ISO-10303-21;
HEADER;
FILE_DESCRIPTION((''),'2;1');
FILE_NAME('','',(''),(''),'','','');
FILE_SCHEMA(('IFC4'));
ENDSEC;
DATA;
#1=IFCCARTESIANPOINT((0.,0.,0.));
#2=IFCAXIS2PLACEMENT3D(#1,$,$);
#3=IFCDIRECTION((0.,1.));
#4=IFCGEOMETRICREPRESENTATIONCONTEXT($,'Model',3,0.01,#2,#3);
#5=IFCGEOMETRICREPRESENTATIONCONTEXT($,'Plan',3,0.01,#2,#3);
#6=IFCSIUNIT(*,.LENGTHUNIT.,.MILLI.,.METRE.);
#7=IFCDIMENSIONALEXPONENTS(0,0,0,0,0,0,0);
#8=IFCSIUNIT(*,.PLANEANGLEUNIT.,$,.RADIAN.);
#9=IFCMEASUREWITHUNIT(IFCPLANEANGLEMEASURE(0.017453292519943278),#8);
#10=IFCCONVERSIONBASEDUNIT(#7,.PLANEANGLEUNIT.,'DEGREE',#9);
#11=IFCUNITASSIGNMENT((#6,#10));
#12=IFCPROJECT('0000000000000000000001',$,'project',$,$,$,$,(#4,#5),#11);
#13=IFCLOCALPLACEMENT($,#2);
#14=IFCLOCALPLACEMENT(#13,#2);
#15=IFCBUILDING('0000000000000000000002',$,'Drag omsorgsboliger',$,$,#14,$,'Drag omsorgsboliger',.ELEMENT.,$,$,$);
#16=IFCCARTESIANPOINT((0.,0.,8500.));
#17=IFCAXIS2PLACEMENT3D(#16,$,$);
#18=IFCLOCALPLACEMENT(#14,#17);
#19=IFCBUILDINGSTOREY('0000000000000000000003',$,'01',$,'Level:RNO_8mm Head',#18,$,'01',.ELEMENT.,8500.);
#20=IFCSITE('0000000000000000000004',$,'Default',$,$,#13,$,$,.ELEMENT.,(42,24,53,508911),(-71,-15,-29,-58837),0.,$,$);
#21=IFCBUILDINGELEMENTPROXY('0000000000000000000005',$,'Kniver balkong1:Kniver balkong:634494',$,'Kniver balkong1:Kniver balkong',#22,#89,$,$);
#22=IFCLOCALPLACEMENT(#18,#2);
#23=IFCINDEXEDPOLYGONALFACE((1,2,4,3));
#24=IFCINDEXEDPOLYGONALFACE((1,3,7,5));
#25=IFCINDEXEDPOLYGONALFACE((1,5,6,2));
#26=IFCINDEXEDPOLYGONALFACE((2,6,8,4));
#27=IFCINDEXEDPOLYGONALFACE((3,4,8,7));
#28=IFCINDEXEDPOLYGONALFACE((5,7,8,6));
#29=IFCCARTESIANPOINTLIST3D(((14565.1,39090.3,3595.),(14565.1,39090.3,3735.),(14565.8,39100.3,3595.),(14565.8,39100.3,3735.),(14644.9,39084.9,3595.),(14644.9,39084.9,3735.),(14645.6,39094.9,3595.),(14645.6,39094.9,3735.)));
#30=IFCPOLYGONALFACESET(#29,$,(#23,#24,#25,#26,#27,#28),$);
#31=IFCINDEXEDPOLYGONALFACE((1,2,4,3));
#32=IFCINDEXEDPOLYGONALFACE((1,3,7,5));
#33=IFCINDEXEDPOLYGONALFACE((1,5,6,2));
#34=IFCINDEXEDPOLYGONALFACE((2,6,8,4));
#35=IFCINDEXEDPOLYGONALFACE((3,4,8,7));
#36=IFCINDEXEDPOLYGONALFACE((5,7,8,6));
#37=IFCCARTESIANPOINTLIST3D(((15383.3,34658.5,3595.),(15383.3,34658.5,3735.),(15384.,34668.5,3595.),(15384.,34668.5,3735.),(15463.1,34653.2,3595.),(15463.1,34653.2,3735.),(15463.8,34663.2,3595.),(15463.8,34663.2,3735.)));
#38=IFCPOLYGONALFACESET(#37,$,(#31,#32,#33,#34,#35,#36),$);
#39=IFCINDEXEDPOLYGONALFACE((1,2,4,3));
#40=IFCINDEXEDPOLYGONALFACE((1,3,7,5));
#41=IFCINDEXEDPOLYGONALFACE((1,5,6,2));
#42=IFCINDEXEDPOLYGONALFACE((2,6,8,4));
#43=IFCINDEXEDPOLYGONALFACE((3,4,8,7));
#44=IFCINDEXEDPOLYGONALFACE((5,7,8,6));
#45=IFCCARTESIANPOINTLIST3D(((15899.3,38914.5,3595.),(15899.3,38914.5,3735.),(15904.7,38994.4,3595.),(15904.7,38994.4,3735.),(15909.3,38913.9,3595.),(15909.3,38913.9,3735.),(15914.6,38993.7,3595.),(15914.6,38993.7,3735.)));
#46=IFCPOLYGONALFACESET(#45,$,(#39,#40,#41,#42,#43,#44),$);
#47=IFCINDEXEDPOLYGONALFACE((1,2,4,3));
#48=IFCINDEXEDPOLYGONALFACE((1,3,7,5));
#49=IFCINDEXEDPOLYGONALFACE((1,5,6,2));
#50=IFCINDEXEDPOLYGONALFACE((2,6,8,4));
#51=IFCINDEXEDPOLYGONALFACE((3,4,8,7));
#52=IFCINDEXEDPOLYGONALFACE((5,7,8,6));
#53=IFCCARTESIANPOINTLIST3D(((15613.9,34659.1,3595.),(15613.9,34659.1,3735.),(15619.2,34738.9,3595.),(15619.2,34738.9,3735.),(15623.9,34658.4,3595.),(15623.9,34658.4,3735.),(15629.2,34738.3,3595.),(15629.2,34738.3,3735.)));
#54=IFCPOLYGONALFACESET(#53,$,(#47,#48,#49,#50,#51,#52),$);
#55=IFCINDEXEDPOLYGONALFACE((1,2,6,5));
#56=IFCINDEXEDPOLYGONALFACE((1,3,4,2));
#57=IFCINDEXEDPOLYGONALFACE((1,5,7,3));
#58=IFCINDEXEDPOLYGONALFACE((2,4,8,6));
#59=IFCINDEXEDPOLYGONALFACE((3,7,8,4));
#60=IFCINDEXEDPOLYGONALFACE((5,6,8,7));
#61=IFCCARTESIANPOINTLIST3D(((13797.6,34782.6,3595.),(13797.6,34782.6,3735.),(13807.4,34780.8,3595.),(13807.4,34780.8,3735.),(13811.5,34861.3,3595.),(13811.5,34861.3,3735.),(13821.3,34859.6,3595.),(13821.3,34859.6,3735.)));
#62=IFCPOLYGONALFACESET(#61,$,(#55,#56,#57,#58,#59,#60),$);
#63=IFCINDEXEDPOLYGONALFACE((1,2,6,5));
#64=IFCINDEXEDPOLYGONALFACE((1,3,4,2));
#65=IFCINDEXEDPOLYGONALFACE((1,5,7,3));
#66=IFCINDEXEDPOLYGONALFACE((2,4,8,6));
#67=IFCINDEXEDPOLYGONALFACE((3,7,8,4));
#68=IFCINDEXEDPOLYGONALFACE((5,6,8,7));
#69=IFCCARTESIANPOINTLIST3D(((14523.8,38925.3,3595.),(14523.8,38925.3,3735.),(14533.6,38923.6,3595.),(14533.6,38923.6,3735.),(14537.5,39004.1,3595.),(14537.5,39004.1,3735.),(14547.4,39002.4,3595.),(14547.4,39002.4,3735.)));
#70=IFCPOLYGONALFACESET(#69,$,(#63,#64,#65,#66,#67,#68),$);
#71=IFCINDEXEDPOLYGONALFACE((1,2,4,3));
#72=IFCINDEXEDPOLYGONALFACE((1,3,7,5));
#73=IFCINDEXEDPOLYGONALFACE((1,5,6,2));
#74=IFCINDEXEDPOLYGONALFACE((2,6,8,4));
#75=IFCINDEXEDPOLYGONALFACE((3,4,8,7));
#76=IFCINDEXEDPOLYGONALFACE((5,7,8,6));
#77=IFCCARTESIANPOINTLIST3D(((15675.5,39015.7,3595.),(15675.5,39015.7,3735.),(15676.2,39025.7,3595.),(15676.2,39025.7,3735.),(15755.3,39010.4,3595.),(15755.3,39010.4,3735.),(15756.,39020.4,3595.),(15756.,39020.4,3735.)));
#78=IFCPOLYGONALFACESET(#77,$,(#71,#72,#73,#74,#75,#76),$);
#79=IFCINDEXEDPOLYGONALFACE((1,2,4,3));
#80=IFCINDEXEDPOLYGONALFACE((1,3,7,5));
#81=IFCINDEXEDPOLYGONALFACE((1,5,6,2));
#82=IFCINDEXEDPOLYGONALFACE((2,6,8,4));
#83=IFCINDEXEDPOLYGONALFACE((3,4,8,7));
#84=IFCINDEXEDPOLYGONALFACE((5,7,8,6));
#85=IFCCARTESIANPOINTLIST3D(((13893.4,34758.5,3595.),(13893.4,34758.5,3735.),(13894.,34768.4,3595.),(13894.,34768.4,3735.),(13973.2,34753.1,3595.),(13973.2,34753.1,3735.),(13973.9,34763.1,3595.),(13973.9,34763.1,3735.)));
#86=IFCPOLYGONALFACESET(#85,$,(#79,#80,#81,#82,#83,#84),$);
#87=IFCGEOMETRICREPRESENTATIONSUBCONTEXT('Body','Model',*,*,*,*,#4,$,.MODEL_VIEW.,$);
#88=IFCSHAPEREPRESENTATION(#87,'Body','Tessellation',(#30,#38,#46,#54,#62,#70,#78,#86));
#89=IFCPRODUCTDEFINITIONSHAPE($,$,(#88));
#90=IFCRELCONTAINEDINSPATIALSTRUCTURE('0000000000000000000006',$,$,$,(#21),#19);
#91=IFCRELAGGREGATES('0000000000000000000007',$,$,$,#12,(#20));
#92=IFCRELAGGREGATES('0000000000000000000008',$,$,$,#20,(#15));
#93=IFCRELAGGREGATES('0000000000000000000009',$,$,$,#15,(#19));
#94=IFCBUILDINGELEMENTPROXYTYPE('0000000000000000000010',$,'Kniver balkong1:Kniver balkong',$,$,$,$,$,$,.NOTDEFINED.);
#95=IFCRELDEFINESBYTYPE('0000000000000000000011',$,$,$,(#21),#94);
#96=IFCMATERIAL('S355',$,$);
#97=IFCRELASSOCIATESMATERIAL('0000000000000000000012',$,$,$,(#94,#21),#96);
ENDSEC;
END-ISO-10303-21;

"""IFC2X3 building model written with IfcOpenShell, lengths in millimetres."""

from ifc_helpers import new_model, entity, si_unit, converted_unit, direction, frame, frame_2d, origin, place, context, subcontext, project, spatial, rectangle, extrude, source, transform, mapped, material, type_object, type_shapes, element, save


model = new_model("IFC2X3")

# Units and contexts
model_context = context("Model", 3, precision=0.01, world=origin(), true_north=direction((0.0, 1.0)))
plan_context = context("Plan", 3, precision=0.01, world=origin(), true_north=direction((0.0, 1.0)))
body_context = subcontext(model_context, "Body", "Model", "MODEL_VIEW")
ifc_project = project(units=[si_unit("LENGTHUNIT", "METRE", prefix="MILLI"), converted_unit("PLANEANGLEUNIT", "DEGREE", entity("IfcPlaneAngleMeasure", 0.017453292519943278), si_unit("PLANEANGLEUNIT", "RADIAN"), dimensions=[0, 0, 0, 0, 0, 0, 0])], contexts=[model_context, plan_context])

# Site, building, storey
site_placement = place(None, origin())
site = spatial("IfcSite", under=ifc_project, at=site_placement, Name="Default", CompositionType="ELEMENT", RefLatitude=(42, 24, 53, 508911), RefLongitude=(-71, -15, -29, -58837), RefElevation=0.0)
building_placement = place(site_placement, origin())
building = spatial("IfcBuilding", under=site, at=building_placement, Name="Drag omsorgsboliger", LongName="Drag omsorgsboliger", CompositionType="ELEMENT")
storey_placement = place(building_placement, frame((0.0, 0.0, 8500.0)))
storey = spatial("IfcBuildingStorey", under=building, at=storey_placement, Name="01", ObjectType="Level:RNO_8mm Head", LongName="01", CompositionType="ELEMENT", Elevation=8500.0)

# Shared definitions
ifc_material = material(Name="S355")

# Building element proxy
building_element_proxy_type_1 = type_object("IfcBuildingElementProxyType", Name="Kniver balkong1:Kniver balkong", PredefinedType="NOTDEFINED", material=ifc_material)
shared_shape_1 = source(origin(), body_context, "Body", "SweptSolid", [
    extrude(rectangle(XDim=10.0, YDim=80.0, at=frame_2d((0.0, 0.0), x_axis=(1.0, 0.0))), frame((14605.3, 39092.6, 12095.0), z_axis=(0.0, 0.0, 1.0), x_axis=(0.066923, 0.997758, 0.0)), (0.0, 0.0, 1.0), 140.0),
    extrude(rectangle(XDim=10.0, YDim=80.0, at=frame_2d((0.0, 0.0), x_axis=(1.0, 0.0))), frame((15423.6, 34660.8, 12095.0), z_axis=(0.0, 0.0, 1.0), x_axis=(0.066923, 0.997758, 0.0)), (0.0, 0.0, 1.0), 140.0),
    extrude(rectangle(XDim=80.0, YDim=10.0, at=frame_2d((0.0, 0.0), x_axis=(1.0, 0.0))), frame((15907.0, 38954.1, 12095.0), z_axis=(0.0, 0.0, 1.0), x_axis=(0.066923, 0.997758, 0.0)), (0.0, 0.0, 1.0), 140.0),
    extrude(rectangle(XDim=80.0, YDim=10.0, at=frame_2d((0.0, 0.0), x_axis=(1.0, 0.0))), frame((15621.6, 34698.7, 12095.0), z_axis=(0.0, 0.0, 1.0), x_axis=(0.066923, 0.997758, 0.0)), (0.0, 0.0, 1.0), 140.0),
    extrude(rectangle(XDim=80.0, YDim=10.0, at=frame_2d((0.0, 0.0), x_axis=(1.0, 0.0))), frame((13809.5, 34821.1, 12095.0), z_axis=(0.0, 0.0, 1.0), x_axis=(0.173601, 0.984816, 0.0)), (0.0, 0.0, 1.0), 140.0),
    extrude(rectangle(XDim=80.0, YDim=10.0, at=frame_2d((0.0, 0.0), x_axis=(1.0, 0.0))), frame((14535.6, 38963.9, 12095.0), z_axis=(0.0, 0.0, 1.0), x_axis=(0.172091, 0.985081, 0.0)), (0.0, 0.0, 1.0), 140.0),
    extrude(rectangle(XDim=10.0, YDim=80.0, at=frame_2d((0.0, 0.0), x_axis=(1.0, 0.0))), frame((15715.7, 39018.1, 12095.0), z_axis=(0.0, 0.0, 1.0), x_axis=(0.066923, 0.997758, 0.0)), (0.0, 0.0, 1.0), 140.0),
    extrude(rectangle(XDim=10.0, YDim=80.0, at=frame_2d((0.0, 0.0), x_axis=(1.0, 0.0))), frame((13933.6, 34760.8, 12095.0), z_axis=(0.0, 0.0, 1.0), x_axis=(0.066923, 0.997758, 0.0)), (0.0, 0.0, 1.0), 140.0),
])
type_shapes(building_element_proxy_type_1, [shared_shape_1])
proxy_1_placement = place(storey_placement, frame((0.0, 0.0, -8500.0)))
element("IfcBuildingElementProxy", 1, at=proxy_1_placement, inside=storey, type_object=building_element_proxy_type_1, material=ifc_material, Name="Kniver balkong1:Kniver balkong:634494", ObjectType="Kniver balkong1:Kniver balkong", context=body_context, shape_type="MappedRepresentation", body=[
    mapped(shared_shape_1, transform((0.0, 0.0, 0.0), scale=1.0)),
])

save(model, "model.ifc")
